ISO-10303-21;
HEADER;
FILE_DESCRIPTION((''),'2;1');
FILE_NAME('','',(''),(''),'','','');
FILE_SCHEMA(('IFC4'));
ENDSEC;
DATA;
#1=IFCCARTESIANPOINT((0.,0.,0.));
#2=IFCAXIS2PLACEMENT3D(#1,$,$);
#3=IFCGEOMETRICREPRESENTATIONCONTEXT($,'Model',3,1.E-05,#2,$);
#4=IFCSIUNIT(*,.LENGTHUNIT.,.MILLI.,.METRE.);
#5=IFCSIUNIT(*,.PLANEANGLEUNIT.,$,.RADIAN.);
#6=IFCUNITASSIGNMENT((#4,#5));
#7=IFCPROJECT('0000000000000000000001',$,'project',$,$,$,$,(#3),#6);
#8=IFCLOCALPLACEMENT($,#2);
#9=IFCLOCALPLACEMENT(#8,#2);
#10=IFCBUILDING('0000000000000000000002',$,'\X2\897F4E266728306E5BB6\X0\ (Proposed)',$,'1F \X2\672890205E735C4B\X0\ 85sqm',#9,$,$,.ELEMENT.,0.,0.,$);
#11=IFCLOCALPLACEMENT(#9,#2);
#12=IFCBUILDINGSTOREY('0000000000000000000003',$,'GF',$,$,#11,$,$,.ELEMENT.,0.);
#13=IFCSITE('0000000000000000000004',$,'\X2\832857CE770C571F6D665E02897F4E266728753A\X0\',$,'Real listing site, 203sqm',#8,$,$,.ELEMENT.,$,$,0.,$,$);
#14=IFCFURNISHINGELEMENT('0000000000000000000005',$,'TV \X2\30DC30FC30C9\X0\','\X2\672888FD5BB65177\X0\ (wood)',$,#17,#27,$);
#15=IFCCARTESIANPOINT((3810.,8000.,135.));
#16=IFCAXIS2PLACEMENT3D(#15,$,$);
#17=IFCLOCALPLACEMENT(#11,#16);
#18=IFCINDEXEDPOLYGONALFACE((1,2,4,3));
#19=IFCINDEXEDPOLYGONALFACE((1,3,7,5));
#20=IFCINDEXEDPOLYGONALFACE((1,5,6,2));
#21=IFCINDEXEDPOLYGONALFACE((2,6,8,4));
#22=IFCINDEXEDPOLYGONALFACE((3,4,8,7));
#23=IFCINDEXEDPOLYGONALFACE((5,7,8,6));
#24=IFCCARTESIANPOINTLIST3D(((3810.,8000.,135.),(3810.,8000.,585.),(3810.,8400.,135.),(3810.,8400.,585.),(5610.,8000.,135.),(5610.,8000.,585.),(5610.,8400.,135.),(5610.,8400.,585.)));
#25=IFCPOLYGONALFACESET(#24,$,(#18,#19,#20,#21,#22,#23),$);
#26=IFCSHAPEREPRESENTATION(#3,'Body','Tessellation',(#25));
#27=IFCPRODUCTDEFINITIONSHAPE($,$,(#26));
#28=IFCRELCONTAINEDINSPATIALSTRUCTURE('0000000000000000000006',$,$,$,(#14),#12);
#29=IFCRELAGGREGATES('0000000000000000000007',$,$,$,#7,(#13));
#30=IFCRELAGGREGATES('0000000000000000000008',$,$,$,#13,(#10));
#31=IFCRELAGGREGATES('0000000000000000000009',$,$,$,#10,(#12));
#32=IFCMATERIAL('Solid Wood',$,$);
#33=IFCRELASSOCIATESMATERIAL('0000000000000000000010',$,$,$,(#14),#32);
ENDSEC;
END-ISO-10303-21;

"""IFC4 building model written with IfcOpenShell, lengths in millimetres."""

from ifc_helpers import new_model, si_unit, frame, frame_2d, origin, place, context, project, spatial, rectangle, extrude, material, element, save


model = new_model("IFC4")

# Units and contexts
model_context = context("Model", 3, precision=1e-05, world=origin())
ifc_project = project(units=[si_unit("LENGTHUNIT", "METRE", prefix="MILLI"), si_unit("PLANEANGLEUNIT", "RADIAN")], contexts=[model_context])

# Site, building, storey
site_placement = place(None, origin())
site = spatial("IfcSite", under=ifc_project, at=site_placement, Name="茨城県土浦市西並木町", ObjectType="Real listing site, 203sqm", CompositionType="ELEMENT", RefElevation=0.0)
building_placement = place(site_placement, origin())
building = spatial("IfcBuilding", under=site, at=building_placement, Name="西並木の家 (Proposed)", ObjectType="1F 木造平屋 85sqm", CompositionType="ELEMENT", ElevationOfRefHeight=0.0, ElevationOfTerrain=0.0)
storey_placement = place(building_placement, origin())
storey = spatial("IfcBuildingStorey", under=building, at=storey_placement, Name="GF", CompositionType="ELEMENT", Elevation=0.0)

# Shared definitions
ifc_material_1 = material(Name="Solid Wood")

# Furnishing element
furnishing_1_placement = place(storey_placement, frame((3810.0, 8000.0, 135.0)))
element("IfcFurnishingElement", 1, at=furnishing_1_placement, inside=storey, material=ifc_material_1, Name="TV ボード", Description="木製家具 (wood)", context=model_context, shape_type="SweptSolid", body=[
    extrude(rectangle(XDim=1800.0, YDim=400.0, at=frame_2d((900.0, 200.0))), frame((3810.0, 8000.0, 135.0)), (0.0, 0.0, 1.0), 450.0),
])

save(model, "model.ifc")
